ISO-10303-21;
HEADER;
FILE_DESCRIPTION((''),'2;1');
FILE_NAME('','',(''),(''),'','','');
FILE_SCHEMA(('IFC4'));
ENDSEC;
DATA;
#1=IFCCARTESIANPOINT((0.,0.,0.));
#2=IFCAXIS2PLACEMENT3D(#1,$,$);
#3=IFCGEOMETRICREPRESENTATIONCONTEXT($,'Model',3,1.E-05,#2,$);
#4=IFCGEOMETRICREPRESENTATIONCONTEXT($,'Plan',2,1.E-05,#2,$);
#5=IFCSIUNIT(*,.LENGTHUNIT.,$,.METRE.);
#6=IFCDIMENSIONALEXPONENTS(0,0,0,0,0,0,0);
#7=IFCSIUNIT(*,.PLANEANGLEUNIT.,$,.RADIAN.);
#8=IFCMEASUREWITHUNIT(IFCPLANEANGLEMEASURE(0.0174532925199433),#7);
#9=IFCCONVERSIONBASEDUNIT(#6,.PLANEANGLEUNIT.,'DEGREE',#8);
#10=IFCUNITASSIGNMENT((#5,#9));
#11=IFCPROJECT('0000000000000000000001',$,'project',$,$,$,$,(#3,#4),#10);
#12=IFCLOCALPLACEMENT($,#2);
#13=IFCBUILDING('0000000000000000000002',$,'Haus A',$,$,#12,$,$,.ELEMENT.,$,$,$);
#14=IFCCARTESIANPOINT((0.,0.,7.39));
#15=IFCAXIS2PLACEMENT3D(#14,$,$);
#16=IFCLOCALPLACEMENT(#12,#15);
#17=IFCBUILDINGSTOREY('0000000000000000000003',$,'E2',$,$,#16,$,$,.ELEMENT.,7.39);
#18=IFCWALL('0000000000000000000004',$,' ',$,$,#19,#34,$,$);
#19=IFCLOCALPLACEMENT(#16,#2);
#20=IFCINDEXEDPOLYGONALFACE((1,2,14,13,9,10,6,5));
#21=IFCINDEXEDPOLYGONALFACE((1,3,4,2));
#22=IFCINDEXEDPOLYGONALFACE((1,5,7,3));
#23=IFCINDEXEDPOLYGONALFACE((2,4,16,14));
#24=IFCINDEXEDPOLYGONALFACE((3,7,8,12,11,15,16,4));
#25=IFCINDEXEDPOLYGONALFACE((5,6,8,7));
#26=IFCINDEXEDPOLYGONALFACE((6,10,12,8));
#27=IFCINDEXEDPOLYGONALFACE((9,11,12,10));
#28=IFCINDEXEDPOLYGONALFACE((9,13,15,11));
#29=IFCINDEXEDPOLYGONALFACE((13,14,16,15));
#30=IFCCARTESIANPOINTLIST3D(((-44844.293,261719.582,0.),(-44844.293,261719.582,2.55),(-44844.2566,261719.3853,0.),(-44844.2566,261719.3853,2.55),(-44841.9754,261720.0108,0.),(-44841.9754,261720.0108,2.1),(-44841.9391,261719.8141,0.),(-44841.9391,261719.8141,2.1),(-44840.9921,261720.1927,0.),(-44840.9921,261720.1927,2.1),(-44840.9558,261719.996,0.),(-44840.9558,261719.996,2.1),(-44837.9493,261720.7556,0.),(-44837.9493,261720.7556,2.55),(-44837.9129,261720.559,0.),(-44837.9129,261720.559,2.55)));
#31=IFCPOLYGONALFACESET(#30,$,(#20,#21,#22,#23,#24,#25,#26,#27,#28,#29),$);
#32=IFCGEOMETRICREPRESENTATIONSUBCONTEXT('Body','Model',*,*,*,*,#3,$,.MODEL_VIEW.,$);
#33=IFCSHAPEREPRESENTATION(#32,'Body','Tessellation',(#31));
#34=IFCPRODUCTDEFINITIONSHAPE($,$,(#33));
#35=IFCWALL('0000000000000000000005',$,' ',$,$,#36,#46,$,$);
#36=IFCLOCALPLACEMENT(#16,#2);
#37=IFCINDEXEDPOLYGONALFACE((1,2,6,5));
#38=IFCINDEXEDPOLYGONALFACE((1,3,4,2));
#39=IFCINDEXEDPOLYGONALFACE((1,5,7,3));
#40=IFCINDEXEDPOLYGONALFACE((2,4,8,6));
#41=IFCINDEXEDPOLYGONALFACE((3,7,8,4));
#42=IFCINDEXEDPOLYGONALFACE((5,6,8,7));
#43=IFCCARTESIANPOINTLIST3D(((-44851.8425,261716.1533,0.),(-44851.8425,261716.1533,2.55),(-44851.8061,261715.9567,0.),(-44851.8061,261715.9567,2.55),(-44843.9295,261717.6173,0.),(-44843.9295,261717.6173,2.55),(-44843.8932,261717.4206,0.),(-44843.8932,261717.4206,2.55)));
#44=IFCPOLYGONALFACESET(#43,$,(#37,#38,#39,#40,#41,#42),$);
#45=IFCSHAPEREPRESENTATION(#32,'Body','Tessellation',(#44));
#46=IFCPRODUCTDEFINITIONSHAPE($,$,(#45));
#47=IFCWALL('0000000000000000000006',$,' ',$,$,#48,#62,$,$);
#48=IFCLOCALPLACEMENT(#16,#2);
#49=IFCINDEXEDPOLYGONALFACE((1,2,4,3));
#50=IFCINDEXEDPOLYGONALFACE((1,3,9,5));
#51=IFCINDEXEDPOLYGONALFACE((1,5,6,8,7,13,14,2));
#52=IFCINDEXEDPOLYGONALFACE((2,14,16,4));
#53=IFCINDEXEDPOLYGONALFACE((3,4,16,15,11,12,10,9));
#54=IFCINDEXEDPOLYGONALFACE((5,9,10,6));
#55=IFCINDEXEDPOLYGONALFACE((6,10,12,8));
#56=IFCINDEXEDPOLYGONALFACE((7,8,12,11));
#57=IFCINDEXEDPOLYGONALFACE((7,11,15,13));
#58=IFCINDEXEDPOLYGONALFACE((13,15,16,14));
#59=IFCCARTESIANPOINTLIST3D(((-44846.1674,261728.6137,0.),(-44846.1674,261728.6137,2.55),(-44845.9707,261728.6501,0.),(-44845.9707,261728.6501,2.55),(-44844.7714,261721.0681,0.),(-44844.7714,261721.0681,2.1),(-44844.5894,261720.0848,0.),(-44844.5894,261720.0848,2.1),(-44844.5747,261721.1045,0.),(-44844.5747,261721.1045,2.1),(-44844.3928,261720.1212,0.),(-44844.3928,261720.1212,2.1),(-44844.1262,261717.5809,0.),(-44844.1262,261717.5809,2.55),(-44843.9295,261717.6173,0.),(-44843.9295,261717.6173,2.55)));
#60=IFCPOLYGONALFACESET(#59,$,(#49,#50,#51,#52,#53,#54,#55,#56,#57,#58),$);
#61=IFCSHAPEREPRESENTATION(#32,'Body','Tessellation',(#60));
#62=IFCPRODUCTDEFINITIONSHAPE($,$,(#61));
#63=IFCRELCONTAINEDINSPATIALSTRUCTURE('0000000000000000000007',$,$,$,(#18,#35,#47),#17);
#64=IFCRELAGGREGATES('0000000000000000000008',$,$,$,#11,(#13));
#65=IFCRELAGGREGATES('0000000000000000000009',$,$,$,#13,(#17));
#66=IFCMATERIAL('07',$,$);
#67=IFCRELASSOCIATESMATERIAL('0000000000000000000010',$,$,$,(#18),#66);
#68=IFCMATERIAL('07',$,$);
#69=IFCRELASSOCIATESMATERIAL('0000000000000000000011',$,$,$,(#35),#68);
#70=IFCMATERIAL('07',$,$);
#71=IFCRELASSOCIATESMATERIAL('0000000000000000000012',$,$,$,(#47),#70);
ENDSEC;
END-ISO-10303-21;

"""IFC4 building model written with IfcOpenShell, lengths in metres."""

from ifc_helpers import new_model, entity, si_unit, converted_unit, frame, frame_2d, origin, origin_with_axes, place, context, subcontext, project, spatial, polyline, rectangle, outline, extrude, material, element, save


model = new_model("IFC4")

# Units and contexts
model_context = context("Model", 3, precision=1e-05, world=origin())
plan_context = context("Plan", 2, precision=1e-05, world=origin())
body_context = subcontext(model_context, "Body", "Model", "MODEL_VIEW")
ifc_project = project(units=[si_unit("LENGTHUNIT", "METRE"), converted_unit("PLANEANGLEUNIT", "DEGREE", entity("IfcPlaneAngleMeasure", 0.0174532925199433), si_unit("PLANEANGLEUNIT", "RADIAN"), dimensions=[0, 0, 0, 0, 0, 0, 0])], contexts=[model_context, plan_context])

# Building, storey
building_placement = place(None, origin())
building = spatial("IfcBuilding", under=ifc_project, at=building_placement, Name="Haus A", CompositionType="ELEMENT")
storey_placement = place(building_placement, frame((0.0, 0.0, 7.39)))
storey = spatial("IfcBuildingStorey", under=building, at=storey_placement, Name="E2", CompositionType="ELEMENT", Elevation=7.39)

# Wall, opening
ifc_material_1 = material(Name="07")
wall_1_placement = place(storey_placement, frame((-44844.2566, 261719.3853, 0.0), z_axis=(0.0, 0.0, 1.0), x_axis=(0.983313, 0.18192, 0.0)))
wall_1 = element("IfcWall", 1, at=wall_1_placement, inside=storey, material=ifc_material_1, Name=" ", context=body_context, shape_type="SweptSolid", body=[
    extrude(rectangle(XDim=6.4514, YDim=0.2, at=frame_2d((3.2257, 0.1), x_axis=(1.0, 0.0))), origin_with_axes(), (0.0, 0.0, 1.0), 2.55),
])
opening_1_placement = place(wall_1_placement, frame((2.3569, 0.0, 0.0), z_axis=(0.0, 1.0, 0.0), x_axis=(0.0, 0.0, 1.0)))
element("IfcOpeningElement", 2, at=opening_1_placement, cuts=wall_1, ObjectType="Opening", context=body_context, shape_type="SweptSolid", body=[
    extrude(outline(polyline([(0.0, 1.0), (2.1, 1.0), (2.1, 0.0), (0.0, 0.0), (0.0, 1.0)])), origin_with_axes(), (0.0, 0.0, 1.0), 0.2),
])

# Wall
ifc_material_2 = material(Name="07")
wall_2_placement = place(storey_placement, frame((-44851.8061, 261715.9567, 0.0), z_axis=(0.0, 0.0, 1.0), x_axis=(0.983313, 0.18192, 0.0)))
element("IfcWall", 3, at=wall_2_placement, inside=storey, material=ifc_material_2, Name=" ", context=body_context, shape_type="SweptSolid", body=[
    extrude(rectangle(XDim=8.0473, YDim=0.2, at=frame_2d((4.0236, 0.1), x_axis=(1.0, 0.0))), origin_with_axes(), (0.0, 0.0, 1.0), 2.55),
])

# Wall, opening
ifc_material_3 = material(Name="07")
wall_3_placement = place(storey_placement, frame((-44843.9295, 261717.6173, 0.0), z_axis=(0.0, 0.0, 1.0), x_axis=(-0.18192, 0.983313, 0.0)))
wall_3 = element("IfcWall", 4, at=wall_3_placement, inside=storey, material=ifc_material_3, Name=" ", context=body_context, shape_type="SweptSolid", body=[
    extrude(rectangle(XDim=11.2201, YDim=0.2, at=frame_2d((5.61, 0.1), x_axis=(1.0, 0.0))), origin_with_axes(), (0.0, 0.0, 1.0), 2.55),
])
opening_2_placement = place(wall_3_placement, frame((2.5464, 0.0, 0.0), z_axis=(0.0, 1.0, 0.0), x_axis=(0.0, 0.0, 1.0)))
element("IfcOpeningElement", 5, at=opening_2_placement, cuts=wall_3, ObjectType="Opening", context=body_context, shape_type="SweptSolid", body=[
    extrude(outline(polyline([(0.0, 1.0), (2.1, 1.0), (2.1, 0.0), (0.0, 0.0), (0.0, 1.0)])), origin_with_axes(), (0.0, 0.0, 1.0), 0.2),
])

save(model, "model.ifc")
